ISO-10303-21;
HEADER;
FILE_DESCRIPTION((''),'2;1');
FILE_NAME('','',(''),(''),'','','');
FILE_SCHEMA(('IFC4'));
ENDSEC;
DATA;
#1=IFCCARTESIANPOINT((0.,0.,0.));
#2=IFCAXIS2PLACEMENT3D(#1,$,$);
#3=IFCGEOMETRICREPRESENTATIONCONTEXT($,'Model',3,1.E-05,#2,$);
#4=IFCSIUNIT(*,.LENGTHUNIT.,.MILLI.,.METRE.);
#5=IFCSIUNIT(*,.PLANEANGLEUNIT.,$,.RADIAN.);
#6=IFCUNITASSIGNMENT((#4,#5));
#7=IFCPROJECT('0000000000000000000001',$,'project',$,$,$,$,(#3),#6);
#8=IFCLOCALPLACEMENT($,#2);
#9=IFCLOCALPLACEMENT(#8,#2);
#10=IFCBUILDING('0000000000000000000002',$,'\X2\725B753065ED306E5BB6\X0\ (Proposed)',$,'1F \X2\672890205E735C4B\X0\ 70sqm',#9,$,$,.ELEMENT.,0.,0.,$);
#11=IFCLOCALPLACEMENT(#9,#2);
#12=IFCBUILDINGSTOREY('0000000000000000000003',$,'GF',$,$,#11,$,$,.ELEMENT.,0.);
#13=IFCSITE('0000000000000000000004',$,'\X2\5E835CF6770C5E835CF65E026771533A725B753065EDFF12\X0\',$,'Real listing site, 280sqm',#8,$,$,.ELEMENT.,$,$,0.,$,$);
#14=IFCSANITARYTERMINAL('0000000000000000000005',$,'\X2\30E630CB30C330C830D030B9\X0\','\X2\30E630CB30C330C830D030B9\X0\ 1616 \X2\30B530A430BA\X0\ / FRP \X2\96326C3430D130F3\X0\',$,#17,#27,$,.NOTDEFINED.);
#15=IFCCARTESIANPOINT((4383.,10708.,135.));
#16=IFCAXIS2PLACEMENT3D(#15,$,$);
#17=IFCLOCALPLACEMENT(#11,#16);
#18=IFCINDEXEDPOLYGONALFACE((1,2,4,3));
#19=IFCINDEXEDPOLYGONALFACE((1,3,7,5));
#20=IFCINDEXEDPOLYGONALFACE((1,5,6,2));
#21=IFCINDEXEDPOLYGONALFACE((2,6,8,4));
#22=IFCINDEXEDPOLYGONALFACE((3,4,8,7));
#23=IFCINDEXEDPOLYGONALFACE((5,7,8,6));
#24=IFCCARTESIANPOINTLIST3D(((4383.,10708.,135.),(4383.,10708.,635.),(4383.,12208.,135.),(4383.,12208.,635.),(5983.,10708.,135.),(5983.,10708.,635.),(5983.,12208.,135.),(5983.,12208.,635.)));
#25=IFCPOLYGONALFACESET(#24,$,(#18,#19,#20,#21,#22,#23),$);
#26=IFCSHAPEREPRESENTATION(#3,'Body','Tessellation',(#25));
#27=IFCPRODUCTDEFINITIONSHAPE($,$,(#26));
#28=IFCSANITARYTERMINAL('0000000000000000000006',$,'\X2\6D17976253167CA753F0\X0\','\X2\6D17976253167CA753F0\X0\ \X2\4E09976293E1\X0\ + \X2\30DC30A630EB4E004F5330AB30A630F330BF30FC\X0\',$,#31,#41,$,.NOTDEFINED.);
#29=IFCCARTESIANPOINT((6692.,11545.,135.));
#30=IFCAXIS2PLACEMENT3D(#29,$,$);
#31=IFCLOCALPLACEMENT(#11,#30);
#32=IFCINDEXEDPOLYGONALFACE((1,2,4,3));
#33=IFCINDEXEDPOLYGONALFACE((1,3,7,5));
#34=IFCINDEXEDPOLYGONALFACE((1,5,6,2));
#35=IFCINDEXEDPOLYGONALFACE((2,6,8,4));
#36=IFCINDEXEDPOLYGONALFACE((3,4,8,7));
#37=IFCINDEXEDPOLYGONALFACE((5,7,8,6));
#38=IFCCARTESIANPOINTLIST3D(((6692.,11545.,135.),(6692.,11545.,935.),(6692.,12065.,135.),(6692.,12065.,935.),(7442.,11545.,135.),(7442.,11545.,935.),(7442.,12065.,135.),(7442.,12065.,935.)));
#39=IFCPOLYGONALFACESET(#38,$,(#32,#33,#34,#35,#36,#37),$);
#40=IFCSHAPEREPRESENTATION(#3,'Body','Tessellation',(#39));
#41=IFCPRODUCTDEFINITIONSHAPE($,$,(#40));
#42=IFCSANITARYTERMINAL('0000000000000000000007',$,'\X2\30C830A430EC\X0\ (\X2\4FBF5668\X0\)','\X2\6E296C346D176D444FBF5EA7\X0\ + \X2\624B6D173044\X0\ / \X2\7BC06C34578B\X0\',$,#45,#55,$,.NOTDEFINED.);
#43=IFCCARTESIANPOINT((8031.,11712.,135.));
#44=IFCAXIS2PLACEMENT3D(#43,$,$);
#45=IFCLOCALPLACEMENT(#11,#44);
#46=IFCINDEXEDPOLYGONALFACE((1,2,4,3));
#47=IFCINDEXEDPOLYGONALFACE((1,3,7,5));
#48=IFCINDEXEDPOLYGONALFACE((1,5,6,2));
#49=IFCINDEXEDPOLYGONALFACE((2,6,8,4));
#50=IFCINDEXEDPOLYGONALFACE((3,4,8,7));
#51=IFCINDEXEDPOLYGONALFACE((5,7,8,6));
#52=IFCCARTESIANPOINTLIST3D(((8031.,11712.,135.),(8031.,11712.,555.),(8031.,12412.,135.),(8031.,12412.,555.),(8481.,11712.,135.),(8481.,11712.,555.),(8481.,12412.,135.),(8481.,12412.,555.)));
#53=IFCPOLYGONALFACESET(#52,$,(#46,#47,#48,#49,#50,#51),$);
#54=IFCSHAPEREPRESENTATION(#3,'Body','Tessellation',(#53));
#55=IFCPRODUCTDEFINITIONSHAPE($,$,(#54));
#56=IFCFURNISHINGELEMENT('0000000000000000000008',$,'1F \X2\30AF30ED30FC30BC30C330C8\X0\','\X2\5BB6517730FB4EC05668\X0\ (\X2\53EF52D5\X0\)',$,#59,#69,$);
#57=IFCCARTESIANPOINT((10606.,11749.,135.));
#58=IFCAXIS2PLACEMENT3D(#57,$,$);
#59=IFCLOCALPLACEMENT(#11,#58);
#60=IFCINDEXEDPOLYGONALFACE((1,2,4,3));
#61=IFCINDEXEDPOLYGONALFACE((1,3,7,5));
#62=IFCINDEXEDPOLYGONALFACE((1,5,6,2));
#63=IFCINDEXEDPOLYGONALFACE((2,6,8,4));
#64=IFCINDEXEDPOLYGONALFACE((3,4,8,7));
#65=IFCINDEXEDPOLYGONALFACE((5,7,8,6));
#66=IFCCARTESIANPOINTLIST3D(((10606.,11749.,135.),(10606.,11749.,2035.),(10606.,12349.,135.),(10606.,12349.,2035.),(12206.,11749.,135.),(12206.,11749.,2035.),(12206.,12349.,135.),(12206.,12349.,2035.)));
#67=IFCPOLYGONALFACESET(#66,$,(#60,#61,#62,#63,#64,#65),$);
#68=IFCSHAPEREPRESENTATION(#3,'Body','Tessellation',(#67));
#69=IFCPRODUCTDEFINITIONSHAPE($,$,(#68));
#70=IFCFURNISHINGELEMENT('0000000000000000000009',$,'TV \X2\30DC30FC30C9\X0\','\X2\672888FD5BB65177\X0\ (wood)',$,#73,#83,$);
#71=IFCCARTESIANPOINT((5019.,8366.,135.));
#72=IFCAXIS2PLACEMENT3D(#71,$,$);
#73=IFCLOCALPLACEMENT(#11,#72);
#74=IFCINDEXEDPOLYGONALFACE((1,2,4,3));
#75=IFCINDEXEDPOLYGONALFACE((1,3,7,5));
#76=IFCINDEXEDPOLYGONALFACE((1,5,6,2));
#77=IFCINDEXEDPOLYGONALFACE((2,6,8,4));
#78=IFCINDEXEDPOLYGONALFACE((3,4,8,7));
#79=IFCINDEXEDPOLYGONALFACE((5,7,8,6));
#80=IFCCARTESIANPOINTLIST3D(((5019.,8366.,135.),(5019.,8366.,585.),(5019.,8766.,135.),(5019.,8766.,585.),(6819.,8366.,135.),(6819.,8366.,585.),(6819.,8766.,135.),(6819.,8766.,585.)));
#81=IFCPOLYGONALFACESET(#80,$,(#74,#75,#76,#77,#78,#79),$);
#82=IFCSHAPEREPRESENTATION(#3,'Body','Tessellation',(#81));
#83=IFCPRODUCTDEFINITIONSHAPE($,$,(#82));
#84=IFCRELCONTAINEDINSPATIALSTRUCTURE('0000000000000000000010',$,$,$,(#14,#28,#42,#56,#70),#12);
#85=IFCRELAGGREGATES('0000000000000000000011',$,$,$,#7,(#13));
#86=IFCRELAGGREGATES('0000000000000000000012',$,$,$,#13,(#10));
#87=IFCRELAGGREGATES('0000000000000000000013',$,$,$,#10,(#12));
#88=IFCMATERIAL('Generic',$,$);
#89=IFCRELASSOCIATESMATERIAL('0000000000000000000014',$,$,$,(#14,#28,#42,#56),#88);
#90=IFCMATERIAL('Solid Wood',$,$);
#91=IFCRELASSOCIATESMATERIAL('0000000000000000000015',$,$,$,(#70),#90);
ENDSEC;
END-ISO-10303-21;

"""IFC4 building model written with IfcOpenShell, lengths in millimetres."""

from ifc_helpers import new_model, si_unit, frame, frame_2d, origin, place, context, project, spatial, rectangle, extrude, material, element, save


model = new_model("IFC4")

# Units and contexts
model_context = context("Model", 3, precision=1e-05, world=origin())
ifc_project = project(units=[si_unit("LENGTHUNIT", "METRE", prefix="MILLI"), si_unit("PLANEANGLEUNIT", "RADIAN")], contexts=[model_context])

# Site, building, storey
site_placement = place(None, origin())
site = spatial("IfcSite", under=ifc_project, at=site_placement, Name="広島県広島市東区牛田旭２", ObjectType="Real listing site, 280sqm", CompositionType="ELEMENT", RefElevation=0.0)
building_placement = place(site_placement, origin())
building = spatial("IfcBuilding", under=site, at=building_placement, Name="牛田旭の家 (Proposed)", ObjectType="1F 木造平屋 70sqm", CompositionType="ELEMENT", ElevationOfRefHeight=0.0, ElevationOfTerrain=0.0)
storey_placement = place(building_placement, origin())
storey = spatial("IfcBuildingStorey", under=building, at=storey_placement, Name="GF", CompositionType="ELEMENT", Elevation=0.0)

# Shared definitions
ifc_material_1 = material(Name="Solid Wood")

# Sanitary terminals
ifc_material_2 = material(Name="Generic")
sanitary_terminal_1_placement = place(storey_placement, frame((4383.0, 10708.0, 135.0)))
element("IfcSanitaryTerminal", 1, at=sanitary_terminal_1_placement, inside=storey, material=ifc_material_2, Name="ユニットバス", Description="ユニットバス 1616 サイズ / FRP 防水パン", PredefinedType="NOTDEFINED", context=model_context, shape_type="SweptSolid", body=[
    extrude(rectangle(XDim=1600.0, YDim=1500.0, at=frame_2d((800.0, 750.0))), frame((4383.0, 10708.0, 135.0)), (0.0, 0.0, 1.0), 500.0),
])
sanitary_terminal_2_placement = place(storey_placement, frame((6692.0, 11545.0, 135.0)))
element("IfcSanitaryTerminal", 2, at=sanitary_terminal_2_placement, inside=storey, material=ifc_material_2, Name="洗面化粧台", Description="洗面化粧台 三面鏡 + ボウル一体カウンター", PredefinedType="NOTDEFINED", context=model_context, shape_type="SweptSolid", body=[
    extrude(rectangle(XDim=750.0, YDim=520.0, at=frame_2d((375.0, 260.0))), frame((6692.0, 11545.0, 135.0)), (0.0, 0.0, 1.0), 800.0),
])
sanitary_terminal_3_placement = place(storey_placement, frame((8031.0, 11712.0, 135.0)))
element("IfcSanitaryTerminal", 3, at=sanitary_terminal_3_placement, inside=storey, material=ifc_material_2, Name="トイレ (便器)", Description="温水洗浄便座 + 手洗い / 節水型", PredefinedType="NOTDEFINED", context=model_context, shape_type="SweptSolid", body=[
    extrude(rectangle(XDim=450.0, YDim=700.0, at=frame_2d((225.0, 350.0))), frame((8031.0, 11712.0, 135.0)), (0.0, 0.0, 1.0), 420.0),
])

# Furnishing elements
furnishing_1_placement = place(storey_placement, frame((10606.0, 11749.0, 135.0)))
element("IfcFurnishingElement", 4, at=furnishing_1_placement, inside=storey, material=ifc_material_2, Name="1F クローゼット", Description="家具・什器 (可動)", context=model_context, shape_type="SweptSolid", body=[
    extrude(rectangle(XDim=1600.0, YDim=600.0, at=frame_2d((800.0, 300.0))), frame((10606.0, 11749.0, 135.0)), (0.0, 0.0, 1.0), 1900.0),
])
furnishing_2_placement = place(storey_placement, frame((5019.0, 8366.0, 135.0)))
element("IfcFurnishingElement", 5, at=furnishing_2_placement, inside=storey, material=ifc_material_1, Name="TV ボード", Description="木製家具 (wood)", context=model_context, shape_type="SweptSolid", body=[
    extrude(rectangle(XDim=1800.0, YDim=400.0, at=frame_2d((900.0, 200.0))), frame((5019.0, 8366.0, 135.0)), (0.0, 0.0, 1.0), 450.0),
])

save(model, "model.ifc")
